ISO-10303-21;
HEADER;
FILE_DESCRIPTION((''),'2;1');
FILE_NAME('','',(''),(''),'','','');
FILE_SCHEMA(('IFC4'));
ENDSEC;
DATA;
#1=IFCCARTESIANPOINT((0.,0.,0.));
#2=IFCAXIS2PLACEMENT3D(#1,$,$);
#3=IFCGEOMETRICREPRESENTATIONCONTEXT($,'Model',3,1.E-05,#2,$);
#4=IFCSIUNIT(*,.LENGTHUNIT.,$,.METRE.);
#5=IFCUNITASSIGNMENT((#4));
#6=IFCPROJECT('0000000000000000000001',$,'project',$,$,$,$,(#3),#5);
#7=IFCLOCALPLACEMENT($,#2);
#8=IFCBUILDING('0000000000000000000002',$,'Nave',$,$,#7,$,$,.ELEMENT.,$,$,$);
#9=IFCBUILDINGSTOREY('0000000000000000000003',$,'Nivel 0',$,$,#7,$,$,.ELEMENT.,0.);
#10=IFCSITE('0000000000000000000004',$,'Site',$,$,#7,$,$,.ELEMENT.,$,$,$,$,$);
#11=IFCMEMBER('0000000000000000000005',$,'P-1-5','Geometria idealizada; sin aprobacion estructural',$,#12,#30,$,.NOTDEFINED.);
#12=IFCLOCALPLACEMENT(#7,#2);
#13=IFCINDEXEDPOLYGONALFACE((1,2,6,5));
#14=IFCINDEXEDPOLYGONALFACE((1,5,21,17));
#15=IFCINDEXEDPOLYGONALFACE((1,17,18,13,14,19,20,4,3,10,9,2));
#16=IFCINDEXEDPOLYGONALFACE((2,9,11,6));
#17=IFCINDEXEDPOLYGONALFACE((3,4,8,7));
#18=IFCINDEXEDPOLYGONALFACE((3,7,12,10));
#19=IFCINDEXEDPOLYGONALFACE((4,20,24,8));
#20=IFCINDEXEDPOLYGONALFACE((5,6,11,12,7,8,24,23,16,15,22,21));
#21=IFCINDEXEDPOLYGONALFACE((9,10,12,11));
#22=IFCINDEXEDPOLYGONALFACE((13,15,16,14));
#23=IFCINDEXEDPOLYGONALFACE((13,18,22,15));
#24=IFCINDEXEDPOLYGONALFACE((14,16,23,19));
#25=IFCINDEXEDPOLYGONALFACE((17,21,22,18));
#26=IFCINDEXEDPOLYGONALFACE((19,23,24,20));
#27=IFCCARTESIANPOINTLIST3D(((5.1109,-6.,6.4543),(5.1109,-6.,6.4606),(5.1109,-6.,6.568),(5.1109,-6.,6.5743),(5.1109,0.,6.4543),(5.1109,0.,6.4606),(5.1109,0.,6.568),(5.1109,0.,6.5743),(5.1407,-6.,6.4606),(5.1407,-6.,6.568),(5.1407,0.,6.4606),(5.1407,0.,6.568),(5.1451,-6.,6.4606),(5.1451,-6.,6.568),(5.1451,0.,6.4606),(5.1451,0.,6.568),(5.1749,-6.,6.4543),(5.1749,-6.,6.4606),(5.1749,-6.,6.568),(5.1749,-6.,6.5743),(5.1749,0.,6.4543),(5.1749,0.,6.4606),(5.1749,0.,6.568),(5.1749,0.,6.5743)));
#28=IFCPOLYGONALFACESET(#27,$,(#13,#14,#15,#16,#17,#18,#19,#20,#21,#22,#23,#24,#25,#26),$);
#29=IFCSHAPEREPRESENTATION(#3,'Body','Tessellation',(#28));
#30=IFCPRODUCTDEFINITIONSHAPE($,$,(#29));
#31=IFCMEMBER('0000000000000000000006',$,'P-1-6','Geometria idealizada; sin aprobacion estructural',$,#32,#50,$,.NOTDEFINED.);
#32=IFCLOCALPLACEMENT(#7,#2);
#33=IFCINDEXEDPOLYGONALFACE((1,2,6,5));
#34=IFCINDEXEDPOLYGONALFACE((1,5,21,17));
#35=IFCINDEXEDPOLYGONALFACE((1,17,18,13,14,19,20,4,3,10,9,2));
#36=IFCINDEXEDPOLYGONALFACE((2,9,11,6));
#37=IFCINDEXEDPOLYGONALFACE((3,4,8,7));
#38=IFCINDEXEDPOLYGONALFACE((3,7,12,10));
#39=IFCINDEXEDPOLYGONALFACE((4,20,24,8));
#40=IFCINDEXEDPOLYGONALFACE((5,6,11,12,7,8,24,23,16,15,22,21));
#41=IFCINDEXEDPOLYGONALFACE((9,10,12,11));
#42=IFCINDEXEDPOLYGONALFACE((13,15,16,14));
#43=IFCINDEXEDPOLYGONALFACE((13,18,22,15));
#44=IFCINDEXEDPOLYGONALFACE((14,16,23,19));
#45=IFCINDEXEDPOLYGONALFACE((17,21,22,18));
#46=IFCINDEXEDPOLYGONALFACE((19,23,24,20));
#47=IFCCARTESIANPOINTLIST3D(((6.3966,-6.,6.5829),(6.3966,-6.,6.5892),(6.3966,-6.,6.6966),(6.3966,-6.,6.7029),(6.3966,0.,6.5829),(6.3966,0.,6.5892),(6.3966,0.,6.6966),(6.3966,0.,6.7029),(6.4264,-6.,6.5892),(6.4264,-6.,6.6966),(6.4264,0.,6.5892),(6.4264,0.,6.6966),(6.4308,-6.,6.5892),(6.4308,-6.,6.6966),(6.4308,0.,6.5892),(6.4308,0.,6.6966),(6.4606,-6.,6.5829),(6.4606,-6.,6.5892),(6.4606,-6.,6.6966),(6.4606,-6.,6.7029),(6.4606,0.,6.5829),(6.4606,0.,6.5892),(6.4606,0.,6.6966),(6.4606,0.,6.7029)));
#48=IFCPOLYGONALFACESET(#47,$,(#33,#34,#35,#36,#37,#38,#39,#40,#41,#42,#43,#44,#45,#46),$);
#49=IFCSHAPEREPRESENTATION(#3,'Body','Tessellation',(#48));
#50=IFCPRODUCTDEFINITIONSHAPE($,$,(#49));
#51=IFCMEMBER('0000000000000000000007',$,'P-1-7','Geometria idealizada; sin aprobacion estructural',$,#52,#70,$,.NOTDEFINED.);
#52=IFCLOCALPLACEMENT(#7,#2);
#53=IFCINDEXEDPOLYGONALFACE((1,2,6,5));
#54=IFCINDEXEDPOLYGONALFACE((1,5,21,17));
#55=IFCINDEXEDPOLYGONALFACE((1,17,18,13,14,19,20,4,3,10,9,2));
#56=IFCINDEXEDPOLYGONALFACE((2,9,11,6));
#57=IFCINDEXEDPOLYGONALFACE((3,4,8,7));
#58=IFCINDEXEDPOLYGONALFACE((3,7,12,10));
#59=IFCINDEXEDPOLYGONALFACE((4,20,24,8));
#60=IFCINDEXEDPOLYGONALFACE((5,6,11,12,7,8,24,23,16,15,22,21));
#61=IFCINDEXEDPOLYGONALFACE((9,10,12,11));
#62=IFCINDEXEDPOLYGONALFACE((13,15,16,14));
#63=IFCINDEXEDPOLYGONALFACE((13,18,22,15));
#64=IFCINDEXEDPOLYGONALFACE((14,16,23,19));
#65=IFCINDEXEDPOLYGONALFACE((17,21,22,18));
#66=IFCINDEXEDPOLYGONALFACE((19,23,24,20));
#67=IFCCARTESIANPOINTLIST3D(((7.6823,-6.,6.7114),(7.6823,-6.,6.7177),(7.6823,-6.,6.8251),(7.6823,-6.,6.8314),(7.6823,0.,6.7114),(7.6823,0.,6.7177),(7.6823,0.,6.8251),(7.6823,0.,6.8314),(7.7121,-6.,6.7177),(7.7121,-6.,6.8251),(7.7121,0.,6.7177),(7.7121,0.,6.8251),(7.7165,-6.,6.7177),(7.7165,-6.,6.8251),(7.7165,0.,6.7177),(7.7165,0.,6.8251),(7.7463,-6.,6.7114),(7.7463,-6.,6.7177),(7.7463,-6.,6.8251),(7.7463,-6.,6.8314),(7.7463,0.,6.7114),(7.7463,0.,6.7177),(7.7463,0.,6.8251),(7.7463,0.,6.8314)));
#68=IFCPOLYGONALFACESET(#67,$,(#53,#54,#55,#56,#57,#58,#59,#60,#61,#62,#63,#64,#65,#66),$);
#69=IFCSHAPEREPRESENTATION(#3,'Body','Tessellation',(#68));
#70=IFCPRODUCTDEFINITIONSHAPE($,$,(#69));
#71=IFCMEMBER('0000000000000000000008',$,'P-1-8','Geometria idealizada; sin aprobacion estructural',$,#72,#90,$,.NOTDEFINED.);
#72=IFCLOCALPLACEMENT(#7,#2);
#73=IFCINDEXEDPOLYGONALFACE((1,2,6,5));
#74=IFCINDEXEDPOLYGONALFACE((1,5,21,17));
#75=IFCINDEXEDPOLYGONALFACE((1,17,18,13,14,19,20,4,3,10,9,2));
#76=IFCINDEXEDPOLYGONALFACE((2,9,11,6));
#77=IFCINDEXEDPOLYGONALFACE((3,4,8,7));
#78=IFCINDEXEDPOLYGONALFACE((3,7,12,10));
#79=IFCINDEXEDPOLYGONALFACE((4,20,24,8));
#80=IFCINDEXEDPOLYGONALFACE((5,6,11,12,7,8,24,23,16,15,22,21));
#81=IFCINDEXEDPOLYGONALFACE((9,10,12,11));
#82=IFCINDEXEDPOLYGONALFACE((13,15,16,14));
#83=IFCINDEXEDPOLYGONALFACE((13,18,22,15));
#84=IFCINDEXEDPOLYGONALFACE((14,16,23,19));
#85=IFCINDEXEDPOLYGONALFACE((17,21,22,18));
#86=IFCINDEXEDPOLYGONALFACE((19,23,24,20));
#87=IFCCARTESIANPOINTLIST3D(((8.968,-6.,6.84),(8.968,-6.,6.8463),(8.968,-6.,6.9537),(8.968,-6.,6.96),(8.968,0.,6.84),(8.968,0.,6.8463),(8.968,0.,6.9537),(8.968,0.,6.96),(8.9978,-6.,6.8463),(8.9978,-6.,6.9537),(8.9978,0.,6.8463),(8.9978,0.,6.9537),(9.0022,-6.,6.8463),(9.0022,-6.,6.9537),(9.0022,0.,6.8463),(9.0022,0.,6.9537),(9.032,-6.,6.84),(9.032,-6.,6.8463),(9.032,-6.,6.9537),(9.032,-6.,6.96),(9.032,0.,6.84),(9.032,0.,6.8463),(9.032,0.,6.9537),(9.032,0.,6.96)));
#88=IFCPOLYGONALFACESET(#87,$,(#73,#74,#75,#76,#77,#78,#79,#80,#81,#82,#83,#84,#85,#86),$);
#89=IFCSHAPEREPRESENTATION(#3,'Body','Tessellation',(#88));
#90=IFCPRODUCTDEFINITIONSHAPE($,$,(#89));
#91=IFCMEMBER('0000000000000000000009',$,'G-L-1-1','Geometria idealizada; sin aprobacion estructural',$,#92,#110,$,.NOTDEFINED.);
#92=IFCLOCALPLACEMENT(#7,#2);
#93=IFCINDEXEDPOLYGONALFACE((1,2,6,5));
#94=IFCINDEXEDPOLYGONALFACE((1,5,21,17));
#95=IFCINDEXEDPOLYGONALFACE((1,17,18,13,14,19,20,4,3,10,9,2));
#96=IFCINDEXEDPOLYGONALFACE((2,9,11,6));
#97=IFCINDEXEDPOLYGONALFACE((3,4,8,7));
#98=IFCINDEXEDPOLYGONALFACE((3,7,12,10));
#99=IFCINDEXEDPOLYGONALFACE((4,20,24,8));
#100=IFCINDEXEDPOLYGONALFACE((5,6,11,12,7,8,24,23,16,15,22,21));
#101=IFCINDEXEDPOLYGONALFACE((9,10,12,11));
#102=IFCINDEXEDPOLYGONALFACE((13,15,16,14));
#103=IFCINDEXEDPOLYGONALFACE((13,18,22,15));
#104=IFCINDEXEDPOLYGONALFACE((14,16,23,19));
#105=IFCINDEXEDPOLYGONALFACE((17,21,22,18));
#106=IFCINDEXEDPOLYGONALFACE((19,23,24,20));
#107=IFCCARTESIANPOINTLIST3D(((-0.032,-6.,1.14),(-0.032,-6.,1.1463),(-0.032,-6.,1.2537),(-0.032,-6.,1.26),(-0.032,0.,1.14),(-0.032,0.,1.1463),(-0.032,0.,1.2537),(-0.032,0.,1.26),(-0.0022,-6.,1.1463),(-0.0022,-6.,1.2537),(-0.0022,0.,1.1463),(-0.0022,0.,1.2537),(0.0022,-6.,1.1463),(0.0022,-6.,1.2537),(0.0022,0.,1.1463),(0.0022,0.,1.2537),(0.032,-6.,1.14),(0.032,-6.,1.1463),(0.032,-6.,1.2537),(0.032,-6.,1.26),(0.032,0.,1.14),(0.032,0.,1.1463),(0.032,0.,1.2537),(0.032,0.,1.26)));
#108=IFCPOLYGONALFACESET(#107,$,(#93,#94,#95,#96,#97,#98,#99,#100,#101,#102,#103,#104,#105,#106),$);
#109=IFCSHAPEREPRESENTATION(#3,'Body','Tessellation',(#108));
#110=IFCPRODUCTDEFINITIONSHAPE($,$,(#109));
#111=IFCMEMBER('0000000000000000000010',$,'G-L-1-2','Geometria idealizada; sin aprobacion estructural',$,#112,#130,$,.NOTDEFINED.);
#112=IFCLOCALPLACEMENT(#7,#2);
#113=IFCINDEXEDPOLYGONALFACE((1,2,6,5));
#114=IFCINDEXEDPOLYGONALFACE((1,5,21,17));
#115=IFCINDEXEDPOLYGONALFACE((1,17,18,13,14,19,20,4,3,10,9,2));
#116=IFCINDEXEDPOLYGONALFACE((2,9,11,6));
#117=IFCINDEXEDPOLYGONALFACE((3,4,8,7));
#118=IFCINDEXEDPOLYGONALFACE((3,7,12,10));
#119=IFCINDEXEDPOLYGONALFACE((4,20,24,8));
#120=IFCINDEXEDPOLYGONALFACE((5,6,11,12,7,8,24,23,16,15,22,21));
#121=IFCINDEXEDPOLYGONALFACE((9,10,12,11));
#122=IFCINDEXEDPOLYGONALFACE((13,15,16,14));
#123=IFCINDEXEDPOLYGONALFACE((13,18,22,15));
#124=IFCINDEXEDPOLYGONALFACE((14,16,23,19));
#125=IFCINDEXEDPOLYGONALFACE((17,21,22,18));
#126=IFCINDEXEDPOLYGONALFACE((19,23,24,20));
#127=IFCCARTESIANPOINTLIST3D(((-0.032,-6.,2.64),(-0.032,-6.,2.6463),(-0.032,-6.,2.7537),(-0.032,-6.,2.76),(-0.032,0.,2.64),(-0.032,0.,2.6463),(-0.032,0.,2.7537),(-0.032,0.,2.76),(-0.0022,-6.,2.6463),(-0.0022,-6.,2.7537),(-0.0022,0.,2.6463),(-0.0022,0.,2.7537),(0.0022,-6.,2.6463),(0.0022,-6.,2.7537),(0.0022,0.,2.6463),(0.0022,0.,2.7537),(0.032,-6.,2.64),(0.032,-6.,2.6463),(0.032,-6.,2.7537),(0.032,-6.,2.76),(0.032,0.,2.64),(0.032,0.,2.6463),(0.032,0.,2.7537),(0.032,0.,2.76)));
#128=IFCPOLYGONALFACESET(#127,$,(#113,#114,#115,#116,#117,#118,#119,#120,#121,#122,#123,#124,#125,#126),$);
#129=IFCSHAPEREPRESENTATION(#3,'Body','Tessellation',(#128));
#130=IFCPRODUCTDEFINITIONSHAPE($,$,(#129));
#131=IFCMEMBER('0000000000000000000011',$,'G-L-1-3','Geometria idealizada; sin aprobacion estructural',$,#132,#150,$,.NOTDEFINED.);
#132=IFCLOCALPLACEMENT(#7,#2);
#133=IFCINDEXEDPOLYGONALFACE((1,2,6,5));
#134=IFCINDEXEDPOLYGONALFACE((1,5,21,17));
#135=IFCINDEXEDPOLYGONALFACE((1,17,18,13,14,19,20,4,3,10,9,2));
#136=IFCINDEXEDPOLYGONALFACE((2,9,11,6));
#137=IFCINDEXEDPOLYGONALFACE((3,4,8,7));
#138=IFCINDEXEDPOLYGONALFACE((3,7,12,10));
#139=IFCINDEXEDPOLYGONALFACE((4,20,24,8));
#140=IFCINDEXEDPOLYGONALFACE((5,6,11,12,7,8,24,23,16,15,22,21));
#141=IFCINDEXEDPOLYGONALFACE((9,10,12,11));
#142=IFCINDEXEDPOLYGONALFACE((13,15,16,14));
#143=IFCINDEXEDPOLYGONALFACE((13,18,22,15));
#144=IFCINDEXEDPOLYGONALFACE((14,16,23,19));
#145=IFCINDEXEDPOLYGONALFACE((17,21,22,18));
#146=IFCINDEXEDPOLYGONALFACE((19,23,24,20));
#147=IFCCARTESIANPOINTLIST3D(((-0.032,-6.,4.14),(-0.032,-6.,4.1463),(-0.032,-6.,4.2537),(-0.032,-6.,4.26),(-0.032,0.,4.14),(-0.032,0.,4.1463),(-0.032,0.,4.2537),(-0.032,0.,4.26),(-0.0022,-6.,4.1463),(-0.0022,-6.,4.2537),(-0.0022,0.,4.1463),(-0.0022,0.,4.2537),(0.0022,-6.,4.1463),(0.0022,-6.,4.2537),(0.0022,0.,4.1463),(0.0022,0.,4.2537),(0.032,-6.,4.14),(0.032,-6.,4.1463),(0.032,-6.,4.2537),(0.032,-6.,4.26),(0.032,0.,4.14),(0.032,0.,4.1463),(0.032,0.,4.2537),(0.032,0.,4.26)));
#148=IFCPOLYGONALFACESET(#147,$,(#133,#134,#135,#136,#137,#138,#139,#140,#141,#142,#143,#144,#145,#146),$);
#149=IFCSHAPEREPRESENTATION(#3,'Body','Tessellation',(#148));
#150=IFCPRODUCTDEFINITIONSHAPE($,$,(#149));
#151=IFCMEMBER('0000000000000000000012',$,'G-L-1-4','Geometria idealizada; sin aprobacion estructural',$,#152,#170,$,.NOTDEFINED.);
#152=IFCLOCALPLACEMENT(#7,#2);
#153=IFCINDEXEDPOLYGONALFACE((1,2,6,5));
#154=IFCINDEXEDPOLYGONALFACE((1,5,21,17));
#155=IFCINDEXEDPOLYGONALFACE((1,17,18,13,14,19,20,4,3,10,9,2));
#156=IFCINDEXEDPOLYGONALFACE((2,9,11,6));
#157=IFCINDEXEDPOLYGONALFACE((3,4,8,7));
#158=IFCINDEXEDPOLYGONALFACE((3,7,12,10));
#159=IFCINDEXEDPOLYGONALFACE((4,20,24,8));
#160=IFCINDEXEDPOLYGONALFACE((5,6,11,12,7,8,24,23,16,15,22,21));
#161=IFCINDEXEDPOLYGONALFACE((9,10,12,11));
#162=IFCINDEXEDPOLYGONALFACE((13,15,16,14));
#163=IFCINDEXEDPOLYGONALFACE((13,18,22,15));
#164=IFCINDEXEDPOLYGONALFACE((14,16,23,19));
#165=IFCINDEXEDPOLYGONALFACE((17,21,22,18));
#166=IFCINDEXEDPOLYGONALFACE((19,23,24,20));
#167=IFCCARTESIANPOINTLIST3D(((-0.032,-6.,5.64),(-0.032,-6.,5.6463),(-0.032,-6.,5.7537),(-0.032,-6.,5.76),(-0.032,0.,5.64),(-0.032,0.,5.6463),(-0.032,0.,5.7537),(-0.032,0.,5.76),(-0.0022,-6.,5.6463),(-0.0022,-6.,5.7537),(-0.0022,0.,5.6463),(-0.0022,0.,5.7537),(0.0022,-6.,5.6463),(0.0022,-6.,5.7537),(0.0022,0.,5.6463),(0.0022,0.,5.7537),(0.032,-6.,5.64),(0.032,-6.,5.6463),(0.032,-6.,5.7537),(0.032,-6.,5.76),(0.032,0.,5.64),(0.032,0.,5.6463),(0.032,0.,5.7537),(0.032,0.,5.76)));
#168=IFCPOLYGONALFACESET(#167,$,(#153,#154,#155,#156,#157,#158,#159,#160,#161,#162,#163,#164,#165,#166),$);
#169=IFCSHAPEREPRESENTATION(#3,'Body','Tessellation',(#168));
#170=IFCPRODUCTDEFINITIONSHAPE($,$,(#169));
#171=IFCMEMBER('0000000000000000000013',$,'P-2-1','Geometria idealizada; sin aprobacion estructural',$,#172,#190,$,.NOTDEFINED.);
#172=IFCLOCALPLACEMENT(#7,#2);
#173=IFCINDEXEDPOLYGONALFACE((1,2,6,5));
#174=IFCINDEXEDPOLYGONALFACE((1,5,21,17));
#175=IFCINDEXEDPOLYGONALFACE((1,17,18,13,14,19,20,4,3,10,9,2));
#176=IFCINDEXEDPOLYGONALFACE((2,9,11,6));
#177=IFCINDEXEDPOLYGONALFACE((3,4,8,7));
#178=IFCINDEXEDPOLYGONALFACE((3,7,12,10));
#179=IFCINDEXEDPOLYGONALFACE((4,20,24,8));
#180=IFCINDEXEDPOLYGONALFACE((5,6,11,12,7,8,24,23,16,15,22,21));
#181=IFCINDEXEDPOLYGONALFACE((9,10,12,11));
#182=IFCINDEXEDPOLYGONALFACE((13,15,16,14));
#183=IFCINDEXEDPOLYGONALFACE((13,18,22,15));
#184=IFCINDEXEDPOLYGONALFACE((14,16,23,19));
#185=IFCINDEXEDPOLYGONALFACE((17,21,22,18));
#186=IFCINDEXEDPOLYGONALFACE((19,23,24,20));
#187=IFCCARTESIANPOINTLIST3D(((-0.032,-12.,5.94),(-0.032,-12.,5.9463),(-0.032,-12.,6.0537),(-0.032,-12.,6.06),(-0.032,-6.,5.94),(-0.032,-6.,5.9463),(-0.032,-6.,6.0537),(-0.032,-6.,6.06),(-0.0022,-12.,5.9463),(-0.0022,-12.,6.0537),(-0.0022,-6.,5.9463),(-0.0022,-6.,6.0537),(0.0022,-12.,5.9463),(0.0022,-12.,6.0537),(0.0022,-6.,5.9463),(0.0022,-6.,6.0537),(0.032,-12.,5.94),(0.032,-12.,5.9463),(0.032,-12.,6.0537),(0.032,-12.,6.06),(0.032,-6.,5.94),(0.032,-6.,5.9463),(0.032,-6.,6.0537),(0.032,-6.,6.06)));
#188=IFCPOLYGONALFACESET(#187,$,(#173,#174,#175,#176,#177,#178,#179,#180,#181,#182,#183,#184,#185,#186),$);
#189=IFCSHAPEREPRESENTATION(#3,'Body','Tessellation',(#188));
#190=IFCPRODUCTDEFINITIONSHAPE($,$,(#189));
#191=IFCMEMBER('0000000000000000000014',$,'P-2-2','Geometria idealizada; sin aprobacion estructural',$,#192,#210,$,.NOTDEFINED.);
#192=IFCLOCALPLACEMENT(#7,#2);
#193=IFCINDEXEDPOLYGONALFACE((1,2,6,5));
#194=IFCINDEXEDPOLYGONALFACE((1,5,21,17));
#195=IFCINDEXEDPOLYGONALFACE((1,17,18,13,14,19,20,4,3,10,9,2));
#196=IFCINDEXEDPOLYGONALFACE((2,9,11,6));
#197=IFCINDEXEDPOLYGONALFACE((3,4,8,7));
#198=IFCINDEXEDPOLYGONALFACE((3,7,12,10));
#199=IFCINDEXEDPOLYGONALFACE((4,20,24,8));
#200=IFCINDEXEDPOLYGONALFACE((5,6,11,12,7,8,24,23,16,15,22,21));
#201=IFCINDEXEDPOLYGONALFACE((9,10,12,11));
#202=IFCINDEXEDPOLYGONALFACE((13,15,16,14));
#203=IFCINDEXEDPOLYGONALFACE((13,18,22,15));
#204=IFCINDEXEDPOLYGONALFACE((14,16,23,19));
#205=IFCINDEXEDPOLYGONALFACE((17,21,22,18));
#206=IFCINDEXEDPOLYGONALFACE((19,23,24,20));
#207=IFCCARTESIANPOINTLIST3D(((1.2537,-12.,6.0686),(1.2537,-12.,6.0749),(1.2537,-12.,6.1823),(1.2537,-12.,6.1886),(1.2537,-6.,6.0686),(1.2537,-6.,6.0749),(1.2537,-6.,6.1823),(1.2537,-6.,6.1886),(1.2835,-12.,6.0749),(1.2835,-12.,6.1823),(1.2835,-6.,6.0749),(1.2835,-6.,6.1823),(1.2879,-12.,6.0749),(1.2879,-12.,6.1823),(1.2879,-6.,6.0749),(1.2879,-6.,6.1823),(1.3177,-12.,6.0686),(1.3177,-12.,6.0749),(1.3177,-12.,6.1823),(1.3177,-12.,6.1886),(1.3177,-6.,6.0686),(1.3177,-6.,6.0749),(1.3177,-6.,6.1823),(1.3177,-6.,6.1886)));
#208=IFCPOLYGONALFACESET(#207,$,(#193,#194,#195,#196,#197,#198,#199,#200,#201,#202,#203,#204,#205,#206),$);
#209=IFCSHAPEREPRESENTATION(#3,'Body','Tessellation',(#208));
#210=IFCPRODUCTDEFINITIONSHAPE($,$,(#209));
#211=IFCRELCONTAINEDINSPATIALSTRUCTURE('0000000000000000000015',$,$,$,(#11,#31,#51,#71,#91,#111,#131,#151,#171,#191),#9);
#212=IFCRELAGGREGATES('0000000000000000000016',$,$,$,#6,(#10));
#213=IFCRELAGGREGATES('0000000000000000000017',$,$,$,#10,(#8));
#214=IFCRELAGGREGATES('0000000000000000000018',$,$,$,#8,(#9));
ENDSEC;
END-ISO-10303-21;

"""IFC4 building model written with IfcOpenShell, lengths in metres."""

from ifc_helpers import new_model, si_unit, frame, origin, place, context, project, spatial, polyline, outline, extrude, element, save


model = new_model("IFC4")

# Units and contexts
model_context = context("Model", 3, precision=1e-05, world=origin())
ifc_project = project(units=[si_unit("LENGTHUNIT", "METRE")], contexts=[model_context])

# Site, building, storey
placement = place(None, origin())
site = spatial("IfcSite", under=ifc_project, at=placement, Name="Site", CompositionType="ELEMENT")
building = spatial("IfcBuilding", under=site, at=placement, Name="Nave", CompositionType="ELEMENT")
storey = spatial("IfcBuildingStorey", under=building, at=placement, Name="Nivel 0", CompositionType="ELEMENT", Elevation=0.0)

# Members
for number, where, z_axis, x_axis, name in (
    (1, (5.1429, 0.0, 6.5143), (0.0, -1.0, 0.0), (1.0, 0.0, 0.0), "P-1-5"),
    (2, (6.4286, 0.0, 6.6429), (0.0, -1.0, 0.0), (1.0, 0.0, 0.0), "P-1-6"),
    (3, (7.7143, 0.0, 6.7714), (0.0, -1.0, 0.0), (1.0, 0.0, 0.0), "P-1-7"),
    (4, (9.0, 0.0, 6.9), (0.0, -1.0, 0.0), (1.0, 0.0, 0.0), "P-1-8"),
    (5, (0.0, 0.0, 1.2), (0.0, -1.0, 0.0), (1.0, 0.0, 0.0), "G-L-1-1"),
    (6, (0.0, 0.0, 2.7), (0.0, -1.0, 0.0), (1.0, 0.0, 0.0), "G-L-1-2"),
    (7, (0.0, 0.0, 4.2), (0.0, -1.0, 0.0), (1.0, 0.0, 0.0), "G-L-1-3"),
    (8, (0.0, 0.0, 5.7), (0.0, -1.0, 0.0), (1.0, 0.0, 0.0), "G-L-1-4"),
    (9, (0.0, -6.0, 6.0), (0.0, -1.0, 0.0), (1.0, 0.0, 0.0), "P-2-1"),
    (10, (1.2857, -6.0, 6.1286), (0.0, -1.0, 0.0), (1.0, 0.0, 0.0), "P-2-2"),
):
    element("IfcMember", number, at=place(placement, frame(where, z_axis=z_axis, x_axis=x_axis)), inside=storey, Name=name, Description="Geometria idealizada; sin aprobacion estructural", PredefinedType="NOTDEFINED", context=model_context, shape_type="SweptSolid", body=[
        extrude(outline(polyline([(-0.032, -0.06), (0.032, -0.06), (0.032, -0.0537), (0.0022, -0.0537), (0.0022, 0.0537), (0.032, 0.0537), (0.032, 0.06), (-0.032, 0.06), (-0.032, 0.0537), (-0.0022, 0.0537), (-0.0022, -0.0537), (-0.032, -0.0537), (-0.032, -0.06)])), origin(), (0.0, 0.0, 1.0), 6.0),
    ])

save(model, "model.ifc")
